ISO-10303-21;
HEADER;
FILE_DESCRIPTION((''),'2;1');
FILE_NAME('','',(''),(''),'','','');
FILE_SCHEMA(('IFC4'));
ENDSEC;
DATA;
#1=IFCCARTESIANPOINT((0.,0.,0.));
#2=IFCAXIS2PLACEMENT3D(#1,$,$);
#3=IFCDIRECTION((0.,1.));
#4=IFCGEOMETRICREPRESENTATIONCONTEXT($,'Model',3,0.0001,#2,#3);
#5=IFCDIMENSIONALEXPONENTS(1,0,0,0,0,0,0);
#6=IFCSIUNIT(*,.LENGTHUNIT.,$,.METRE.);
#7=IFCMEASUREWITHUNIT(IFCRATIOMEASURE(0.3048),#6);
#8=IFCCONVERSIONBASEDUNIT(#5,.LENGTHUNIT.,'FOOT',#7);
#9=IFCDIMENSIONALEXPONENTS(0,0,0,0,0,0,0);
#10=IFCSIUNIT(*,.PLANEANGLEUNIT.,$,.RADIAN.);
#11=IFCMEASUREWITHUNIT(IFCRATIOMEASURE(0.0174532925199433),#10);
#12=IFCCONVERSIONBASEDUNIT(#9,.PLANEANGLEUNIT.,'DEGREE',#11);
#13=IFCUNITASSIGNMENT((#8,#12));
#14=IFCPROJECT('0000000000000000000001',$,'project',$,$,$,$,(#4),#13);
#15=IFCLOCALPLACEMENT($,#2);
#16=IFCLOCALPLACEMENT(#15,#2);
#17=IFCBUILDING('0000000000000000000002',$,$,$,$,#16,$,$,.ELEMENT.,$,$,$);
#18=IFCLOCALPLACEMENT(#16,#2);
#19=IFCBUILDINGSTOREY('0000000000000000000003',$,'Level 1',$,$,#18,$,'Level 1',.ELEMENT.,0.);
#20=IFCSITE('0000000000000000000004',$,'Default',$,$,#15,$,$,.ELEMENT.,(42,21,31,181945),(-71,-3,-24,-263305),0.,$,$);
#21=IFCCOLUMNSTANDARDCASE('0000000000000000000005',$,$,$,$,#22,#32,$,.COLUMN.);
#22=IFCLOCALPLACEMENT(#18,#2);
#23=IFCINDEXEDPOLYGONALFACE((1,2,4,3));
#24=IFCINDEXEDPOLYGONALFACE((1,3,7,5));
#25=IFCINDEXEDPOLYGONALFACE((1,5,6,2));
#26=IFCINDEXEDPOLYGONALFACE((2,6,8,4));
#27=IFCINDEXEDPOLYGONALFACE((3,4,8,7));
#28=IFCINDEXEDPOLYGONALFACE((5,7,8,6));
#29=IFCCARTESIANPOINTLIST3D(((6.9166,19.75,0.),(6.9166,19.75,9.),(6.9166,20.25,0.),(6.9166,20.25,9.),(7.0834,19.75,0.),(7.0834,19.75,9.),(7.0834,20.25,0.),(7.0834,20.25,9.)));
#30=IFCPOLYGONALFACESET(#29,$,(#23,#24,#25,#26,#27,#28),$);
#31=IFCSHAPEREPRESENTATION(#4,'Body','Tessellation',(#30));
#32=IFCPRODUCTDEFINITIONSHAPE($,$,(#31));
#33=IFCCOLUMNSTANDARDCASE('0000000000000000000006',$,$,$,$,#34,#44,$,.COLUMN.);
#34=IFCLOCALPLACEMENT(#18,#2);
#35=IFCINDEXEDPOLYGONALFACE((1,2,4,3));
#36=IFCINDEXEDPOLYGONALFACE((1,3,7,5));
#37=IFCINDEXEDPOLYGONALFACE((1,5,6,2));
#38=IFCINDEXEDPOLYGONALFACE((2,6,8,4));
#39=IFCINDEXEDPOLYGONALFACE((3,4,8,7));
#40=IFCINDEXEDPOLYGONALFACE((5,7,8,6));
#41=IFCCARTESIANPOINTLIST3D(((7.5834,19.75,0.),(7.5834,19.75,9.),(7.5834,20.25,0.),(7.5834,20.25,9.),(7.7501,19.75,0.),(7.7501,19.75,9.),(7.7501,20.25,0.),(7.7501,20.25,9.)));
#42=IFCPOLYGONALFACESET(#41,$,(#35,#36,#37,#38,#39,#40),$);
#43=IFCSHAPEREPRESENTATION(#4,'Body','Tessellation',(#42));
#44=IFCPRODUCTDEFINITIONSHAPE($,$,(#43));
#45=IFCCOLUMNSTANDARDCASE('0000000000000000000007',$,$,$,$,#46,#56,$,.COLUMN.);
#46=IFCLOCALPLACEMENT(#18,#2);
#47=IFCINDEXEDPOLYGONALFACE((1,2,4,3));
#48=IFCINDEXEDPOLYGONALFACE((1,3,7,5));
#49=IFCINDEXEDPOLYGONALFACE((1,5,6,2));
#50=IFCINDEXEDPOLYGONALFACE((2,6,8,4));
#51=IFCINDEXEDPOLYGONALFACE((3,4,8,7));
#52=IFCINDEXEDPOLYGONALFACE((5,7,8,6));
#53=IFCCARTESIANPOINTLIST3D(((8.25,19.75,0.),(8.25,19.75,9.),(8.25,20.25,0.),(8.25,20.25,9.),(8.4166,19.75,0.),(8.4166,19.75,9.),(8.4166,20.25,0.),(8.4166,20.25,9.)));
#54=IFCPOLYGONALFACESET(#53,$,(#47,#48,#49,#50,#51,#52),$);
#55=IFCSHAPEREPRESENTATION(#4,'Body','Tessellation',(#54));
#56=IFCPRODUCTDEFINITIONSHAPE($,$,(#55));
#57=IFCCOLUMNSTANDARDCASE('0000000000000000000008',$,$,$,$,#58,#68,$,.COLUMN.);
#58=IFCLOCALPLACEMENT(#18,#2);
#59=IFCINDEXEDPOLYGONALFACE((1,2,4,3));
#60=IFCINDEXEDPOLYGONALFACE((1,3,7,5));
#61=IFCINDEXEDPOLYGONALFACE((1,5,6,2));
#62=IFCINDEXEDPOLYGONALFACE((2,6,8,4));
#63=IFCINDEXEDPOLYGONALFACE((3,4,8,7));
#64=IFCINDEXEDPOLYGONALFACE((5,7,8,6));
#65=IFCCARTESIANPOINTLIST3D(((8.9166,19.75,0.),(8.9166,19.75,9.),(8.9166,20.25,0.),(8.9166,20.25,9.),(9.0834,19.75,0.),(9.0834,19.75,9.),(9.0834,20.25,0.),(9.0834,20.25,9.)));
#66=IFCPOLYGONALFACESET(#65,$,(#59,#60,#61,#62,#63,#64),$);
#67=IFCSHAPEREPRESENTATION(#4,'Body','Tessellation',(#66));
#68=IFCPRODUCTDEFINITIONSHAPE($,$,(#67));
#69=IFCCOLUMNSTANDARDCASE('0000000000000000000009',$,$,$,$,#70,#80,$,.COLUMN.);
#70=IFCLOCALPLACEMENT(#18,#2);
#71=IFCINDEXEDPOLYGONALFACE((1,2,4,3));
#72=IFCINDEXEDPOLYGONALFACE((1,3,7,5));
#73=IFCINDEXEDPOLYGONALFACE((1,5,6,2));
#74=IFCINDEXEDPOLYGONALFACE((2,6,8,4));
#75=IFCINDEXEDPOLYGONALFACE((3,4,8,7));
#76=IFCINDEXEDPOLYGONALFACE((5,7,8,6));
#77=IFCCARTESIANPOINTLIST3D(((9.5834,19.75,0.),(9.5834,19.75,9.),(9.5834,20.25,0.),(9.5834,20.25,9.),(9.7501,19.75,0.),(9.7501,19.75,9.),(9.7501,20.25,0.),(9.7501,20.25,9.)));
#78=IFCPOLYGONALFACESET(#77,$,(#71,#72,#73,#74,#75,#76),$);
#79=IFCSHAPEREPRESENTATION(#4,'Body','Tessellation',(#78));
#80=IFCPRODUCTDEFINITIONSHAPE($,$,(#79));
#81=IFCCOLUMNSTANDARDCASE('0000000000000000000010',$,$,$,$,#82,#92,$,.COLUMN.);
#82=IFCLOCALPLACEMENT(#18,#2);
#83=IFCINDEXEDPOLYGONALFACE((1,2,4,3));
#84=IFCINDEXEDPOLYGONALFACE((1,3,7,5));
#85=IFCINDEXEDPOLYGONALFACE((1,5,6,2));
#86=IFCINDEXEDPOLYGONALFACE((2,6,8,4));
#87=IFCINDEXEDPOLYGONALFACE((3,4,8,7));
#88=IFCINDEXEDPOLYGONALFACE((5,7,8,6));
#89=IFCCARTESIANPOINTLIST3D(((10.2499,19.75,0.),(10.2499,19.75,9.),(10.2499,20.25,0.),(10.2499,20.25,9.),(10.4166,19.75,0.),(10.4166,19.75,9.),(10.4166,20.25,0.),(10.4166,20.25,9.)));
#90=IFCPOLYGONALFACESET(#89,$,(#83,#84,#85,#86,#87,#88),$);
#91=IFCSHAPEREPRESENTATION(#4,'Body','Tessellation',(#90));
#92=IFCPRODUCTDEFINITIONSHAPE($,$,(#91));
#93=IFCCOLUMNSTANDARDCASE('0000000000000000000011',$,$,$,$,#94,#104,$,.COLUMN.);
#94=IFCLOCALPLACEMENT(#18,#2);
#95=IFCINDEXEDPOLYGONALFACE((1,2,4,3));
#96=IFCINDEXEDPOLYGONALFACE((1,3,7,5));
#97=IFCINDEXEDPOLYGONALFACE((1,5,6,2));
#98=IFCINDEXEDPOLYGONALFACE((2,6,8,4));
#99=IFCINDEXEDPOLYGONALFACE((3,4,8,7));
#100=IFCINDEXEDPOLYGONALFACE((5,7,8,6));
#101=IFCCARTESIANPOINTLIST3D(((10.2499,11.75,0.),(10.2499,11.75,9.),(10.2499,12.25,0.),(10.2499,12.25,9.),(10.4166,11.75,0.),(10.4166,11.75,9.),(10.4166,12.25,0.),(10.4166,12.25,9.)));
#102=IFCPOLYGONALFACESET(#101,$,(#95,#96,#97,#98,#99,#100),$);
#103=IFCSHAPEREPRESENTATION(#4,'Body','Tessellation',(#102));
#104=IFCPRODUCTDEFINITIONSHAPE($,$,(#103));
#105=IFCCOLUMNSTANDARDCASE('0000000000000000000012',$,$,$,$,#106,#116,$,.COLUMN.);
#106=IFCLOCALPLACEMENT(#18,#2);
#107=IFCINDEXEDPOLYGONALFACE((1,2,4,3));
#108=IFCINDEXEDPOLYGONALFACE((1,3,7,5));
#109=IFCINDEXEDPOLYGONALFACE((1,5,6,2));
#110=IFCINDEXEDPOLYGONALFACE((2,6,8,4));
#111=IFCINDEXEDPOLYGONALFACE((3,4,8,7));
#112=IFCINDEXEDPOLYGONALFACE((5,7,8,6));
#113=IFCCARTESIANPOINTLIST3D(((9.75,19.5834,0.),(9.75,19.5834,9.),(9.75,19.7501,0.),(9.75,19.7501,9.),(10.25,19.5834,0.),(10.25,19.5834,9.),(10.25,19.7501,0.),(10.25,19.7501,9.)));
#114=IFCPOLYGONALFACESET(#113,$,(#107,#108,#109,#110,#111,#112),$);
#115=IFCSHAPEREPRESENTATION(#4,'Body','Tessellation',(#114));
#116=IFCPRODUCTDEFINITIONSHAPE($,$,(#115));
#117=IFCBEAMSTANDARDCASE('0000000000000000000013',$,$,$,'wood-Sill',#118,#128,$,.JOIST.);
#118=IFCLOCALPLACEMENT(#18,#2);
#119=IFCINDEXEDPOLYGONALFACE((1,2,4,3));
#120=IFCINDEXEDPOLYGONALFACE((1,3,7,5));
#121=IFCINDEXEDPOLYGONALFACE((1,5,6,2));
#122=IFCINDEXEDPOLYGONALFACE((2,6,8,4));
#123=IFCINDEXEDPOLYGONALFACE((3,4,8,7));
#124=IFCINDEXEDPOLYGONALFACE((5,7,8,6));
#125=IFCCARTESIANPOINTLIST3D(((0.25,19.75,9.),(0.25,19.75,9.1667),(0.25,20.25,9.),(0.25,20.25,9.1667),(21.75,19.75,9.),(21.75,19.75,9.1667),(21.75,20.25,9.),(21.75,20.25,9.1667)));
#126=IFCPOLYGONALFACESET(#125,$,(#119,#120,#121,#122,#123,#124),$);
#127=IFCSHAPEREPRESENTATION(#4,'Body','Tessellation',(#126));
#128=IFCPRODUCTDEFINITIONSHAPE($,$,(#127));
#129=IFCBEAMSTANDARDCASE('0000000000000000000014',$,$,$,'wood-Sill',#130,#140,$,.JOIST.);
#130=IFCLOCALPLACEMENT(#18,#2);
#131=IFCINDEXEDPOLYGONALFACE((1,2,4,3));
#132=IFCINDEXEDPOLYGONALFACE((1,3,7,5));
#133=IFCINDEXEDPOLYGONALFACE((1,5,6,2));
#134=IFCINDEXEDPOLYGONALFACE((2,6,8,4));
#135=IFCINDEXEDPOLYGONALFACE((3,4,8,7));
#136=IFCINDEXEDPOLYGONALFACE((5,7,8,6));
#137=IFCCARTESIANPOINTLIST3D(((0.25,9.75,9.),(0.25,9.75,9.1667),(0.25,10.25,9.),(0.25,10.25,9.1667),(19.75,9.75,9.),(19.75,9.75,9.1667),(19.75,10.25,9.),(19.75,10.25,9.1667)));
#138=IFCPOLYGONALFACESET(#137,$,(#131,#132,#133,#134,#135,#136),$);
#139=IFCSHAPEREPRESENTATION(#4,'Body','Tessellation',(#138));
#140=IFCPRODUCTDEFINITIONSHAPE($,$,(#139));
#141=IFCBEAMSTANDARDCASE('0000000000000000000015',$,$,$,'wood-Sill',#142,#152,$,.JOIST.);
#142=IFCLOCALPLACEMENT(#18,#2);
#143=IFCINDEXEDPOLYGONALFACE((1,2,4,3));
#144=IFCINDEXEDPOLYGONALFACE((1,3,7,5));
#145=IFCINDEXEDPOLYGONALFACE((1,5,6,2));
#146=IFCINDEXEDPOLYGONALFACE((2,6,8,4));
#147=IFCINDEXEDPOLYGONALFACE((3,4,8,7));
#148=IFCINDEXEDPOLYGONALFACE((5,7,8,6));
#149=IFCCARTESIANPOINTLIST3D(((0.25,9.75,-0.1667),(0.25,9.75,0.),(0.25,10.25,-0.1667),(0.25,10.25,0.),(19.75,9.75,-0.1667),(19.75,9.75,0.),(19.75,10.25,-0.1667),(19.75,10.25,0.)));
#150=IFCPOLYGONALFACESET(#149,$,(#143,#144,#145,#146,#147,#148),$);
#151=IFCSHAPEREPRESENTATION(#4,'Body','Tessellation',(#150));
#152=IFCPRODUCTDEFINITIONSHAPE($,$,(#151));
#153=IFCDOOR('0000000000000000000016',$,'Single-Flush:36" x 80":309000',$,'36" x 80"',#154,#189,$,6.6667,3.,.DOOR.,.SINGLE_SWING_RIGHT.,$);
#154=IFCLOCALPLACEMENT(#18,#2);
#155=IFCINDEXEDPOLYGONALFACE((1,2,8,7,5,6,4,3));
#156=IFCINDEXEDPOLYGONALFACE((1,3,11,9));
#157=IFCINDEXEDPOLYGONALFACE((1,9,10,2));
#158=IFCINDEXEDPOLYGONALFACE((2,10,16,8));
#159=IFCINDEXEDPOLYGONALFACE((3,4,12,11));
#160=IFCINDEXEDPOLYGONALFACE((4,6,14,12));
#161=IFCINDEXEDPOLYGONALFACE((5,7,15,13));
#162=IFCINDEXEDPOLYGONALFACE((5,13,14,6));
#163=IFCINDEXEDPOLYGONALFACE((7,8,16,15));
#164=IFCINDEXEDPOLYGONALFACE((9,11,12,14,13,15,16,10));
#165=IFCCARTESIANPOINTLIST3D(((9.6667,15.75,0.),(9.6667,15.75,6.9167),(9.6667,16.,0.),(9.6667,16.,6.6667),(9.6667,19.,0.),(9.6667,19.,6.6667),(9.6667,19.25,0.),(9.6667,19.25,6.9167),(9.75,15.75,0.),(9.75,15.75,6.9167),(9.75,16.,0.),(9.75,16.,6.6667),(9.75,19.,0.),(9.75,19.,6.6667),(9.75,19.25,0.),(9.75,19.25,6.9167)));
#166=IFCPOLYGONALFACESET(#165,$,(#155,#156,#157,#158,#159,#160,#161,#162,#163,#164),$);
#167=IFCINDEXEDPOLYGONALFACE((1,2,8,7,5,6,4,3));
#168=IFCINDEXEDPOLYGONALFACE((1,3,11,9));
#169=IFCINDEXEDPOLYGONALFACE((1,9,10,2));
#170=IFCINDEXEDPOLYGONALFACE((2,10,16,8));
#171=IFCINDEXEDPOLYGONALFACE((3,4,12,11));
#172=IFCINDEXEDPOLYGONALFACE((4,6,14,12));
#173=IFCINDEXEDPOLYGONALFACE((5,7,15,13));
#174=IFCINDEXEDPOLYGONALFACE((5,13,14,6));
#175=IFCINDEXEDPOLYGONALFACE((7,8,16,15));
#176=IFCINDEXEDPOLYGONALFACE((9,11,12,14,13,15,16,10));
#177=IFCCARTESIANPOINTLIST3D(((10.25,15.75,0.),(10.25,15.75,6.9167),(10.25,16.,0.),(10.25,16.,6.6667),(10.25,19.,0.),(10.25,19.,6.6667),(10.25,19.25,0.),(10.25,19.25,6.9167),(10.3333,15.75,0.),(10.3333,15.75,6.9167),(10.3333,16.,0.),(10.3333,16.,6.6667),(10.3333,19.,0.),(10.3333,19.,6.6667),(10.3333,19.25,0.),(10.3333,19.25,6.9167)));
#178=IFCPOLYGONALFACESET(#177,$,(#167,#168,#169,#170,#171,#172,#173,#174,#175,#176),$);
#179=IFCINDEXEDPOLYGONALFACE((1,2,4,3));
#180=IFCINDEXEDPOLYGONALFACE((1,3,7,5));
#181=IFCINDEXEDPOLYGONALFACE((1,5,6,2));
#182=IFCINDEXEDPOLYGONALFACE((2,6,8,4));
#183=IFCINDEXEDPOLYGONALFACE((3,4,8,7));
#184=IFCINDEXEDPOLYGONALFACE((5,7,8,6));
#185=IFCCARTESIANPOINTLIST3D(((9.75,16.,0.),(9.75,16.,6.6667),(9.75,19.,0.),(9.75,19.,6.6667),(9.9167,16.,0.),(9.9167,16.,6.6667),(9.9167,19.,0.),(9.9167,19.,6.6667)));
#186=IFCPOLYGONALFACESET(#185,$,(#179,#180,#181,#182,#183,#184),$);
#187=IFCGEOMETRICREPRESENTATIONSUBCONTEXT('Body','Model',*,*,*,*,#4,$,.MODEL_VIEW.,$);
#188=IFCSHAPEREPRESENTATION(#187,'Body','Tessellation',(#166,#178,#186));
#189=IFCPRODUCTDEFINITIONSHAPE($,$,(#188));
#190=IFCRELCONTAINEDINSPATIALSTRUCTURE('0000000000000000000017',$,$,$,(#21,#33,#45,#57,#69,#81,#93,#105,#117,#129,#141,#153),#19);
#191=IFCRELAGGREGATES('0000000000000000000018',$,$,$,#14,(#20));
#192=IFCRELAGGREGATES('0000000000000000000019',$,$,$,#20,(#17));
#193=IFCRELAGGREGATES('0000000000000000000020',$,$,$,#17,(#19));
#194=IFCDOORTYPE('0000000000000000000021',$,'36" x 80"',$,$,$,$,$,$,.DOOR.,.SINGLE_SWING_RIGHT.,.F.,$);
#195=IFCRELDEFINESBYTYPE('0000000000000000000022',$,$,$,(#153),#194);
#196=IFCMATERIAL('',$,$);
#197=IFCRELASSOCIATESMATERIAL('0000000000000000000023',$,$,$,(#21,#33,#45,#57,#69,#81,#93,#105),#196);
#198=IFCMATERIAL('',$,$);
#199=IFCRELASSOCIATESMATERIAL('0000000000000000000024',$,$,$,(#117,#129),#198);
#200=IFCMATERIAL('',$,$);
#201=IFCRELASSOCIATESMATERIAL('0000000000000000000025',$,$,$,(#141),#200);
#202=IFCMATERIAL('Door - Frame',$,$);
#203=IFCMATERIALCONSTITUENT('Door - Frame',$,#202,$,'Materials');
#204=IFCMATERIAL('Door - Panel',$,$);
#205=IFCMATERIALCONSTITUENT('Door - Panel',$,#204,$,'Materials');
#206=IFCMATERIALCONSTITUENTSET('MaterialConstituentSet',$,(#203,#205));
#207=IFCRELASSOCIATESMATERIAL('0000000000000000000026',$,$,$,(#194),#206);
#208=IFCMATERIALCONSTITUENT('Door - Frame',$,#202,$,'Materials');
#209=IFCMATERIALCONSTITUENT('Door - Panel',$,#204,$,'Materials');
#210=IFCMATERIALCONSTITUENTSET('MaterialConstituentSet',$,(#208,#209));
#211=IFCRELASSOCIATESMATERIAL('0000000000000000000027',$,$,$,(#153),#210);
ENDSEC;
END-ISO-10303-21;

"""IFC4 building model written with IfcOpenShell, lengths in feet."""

from ifc_helpers import new_model, entity, si_unit, converted_unit, direction, frame, origin, origin_2d_with_axis, place, context, subcontext, project, spatial, polyline, rectangle, outline, extrude, source, transform, mapped, material, constituent, constituent_set, type_object, type_shapes, element, save


model = new_model("IFC4")

# Units and contexts
model_context = context("Model", 3, precision=0.0001, world=origin(), true_north=direction((0.0, 1.0)))
body_context = subcontext(model_context, "Body", "Model", "MODEL_VIEW")
ifc_project = project(units=[converted_unit("LENGTHUNIT", "FOOT", entity("IfcRatioMeasure", 0.3048), si_unit("LENGTHUNIT", "METRE"), dimensions=[1, 0, 0, 0, 0, 0, 0]), converted_unit("PLANEANGLEUNIT", "DEGREE", entity("IfcRatioMeasure", 0.0174532925199433), si_unit("PLANEANGLEUNIT", "RADIAN"), dimensions=[0, 0, 0, 0, 0, 0, 0])], contexts=[model_context])

# Site, building, storey
site_placement = place(None, origin())
site = spatial("IfcSite", under=ifc_project, at=site_placement, Name="Default", CompositionType="ELEMENT", RefLatitude=(42, 21, 31, 181945), RefLongitude=(-71, -3, -24, -263305), RefElevation=0.0)
building_placement = place(site_placement, origin())
building = spatial("IfcBuilding", under=site, at=building_placement, CompositionType="ELEMENT")
storey_placement = place(building_placement, origin())
storey = spatial("IfcBuildingStorey", under=building, at=storey_placement, Name="Level 1", LongName="Level 1", CompositionType="ELEMENT", Elevation=0.0)

# Columns
ifc_material_1 = material(Name="")
placement_1 = place(storey_placement, frame((0.25, 20.0, 0.0)))
for number, where, z_axis, x_axis in (
    (1, (6.75, 0.0, 0.0), (0.0, 0.0, 1.0), (1.0, 0.0, 0.0)),
    (2, (7.4167, 0.0, 0.0), (0.0, 0.0, 1.0), (1.0, 0.0, 0.0)),
    (3, (8.0833, 0.0, 0.0), (0.0, 0.0, 1.0), (1.0, 0.0, 0.0)),
    (4, (8.75, 0.0, 0.0), (0.0, 0.0, 1.0), (1.0, 0.0, 0.0)),
    (5, (9.4167, 0.0, 0.0), (0.0, 0.0, 1.0), (1.0, 0.0, 0.0)),
    (6, (10.0833, 0.0, 0.0), (0.0, 0.0, 1.0), (1.0, 0.0, 0.0)),
):
    element("IfcColumnStandardCase", number, at=place(placement_1, frame(where, z_axis=z_axis, x_axis=x_axis)), inside=storey, material=ifc_material_1, PredefinedType="COLUMN", context=model_context, shape_type="SweptSolid", body=[
        extrude(rectangle(XDim=0.1667, YDim=0.5), origin(), (0.0, 0.0, 1.0), 9.0),
    ])
placement_2 = place(storey_placement, frame((10.25, 12.0, 0.0)))
for number, where, z_axis, x_axis in (
    (7, (0.0833, 0.0, 0.0), (0.0, 0.0, 1.0), (1.0, 0.0, 0.0)),
):
    element("IfcColumnStandardCase", number, at=place(placement_2, frame(where, z_axis=z_axis, x_axis=x_axis)), inside=storey, material=ifc_material_1, PredefinedType="COLUMN", context=model_context, shape_type="SweptSolid", body=[
        extrude(rectangle(XDim=0.1667, YDim=0.5), origin(), (0.0, 0.0, 1.0), 9.0),
    ])
placement_3 = place(storey_placement, frame((10.0, 19.75, 0.0), z_axis=(0.0, 0.0, 1.0), x_axis=(0.0, -1.0, 0.0)))
for number, where, z_axis, x_axis in (
    (8, (0.0833, 0.0, 0.0), (0.0, 0.0, 1.0), (1.0, 0.0, 0.0)),
):
    element("IfcColumnStandardCase", number, at=place(placement_3, frame(where, z_axis=z_axis, x_axis=x_axis)), inside=storey, material=ifc_material_1, PredefinedType="COLUMN", context=model_context, shape_type="SweptSolid", body=[
        extrude(rectangle(XDim=0.1667, YDim=0.5), origin(), (0.0, 0.0, 1.0), 9.0),
    ])

# Beams
ifc_material_2 = material(Name="")
beam_1_placement = place(placement_1, frame((10.75, 0.0, 9.0), z_axis=(0.0, 0.0, 1.0), x_axis=(1.0, 0.0, 0.0)))
element("IfcBeamStandardCase", 9, at=beam_1_placement, inside=storey, material=ifc_material_2, ObjectType="wood-Sill", PredefinedType="JOIST", context=model_context, shape_type="SweptSolid", body=[
    extrude(rectangle(XDim=21.5, YDim=0.5), origin(), (0.0, 0.0, 1.0), 0.1667),
])
beam_2_placement = place(placement_3, frame((9.75, 0.0, 9.0), z_axis=(0.0, 0.0, 1.0), x_axis=(0.0, -1.0, 0.0)))
element("IfcBeamStandardCase", 10, at=beam_2_placement, inside=storey, material=ifc_material_2, ObjectType="wood-Sill", PredefinedType="JOIST", context=model_context, shape_type="SweptSolid", body=[
    extrude(rectangle(XDim=19.5, YDim=0.5), origin(), (0.0, 0.0, 1.0), 0.1667),
])
ifc_material_3 = material(Name="")
beam_3_placement = place(placement_3, frame((9.75, 0.0, -0.1667), z_axis=(0.0, 0.0, 1.0), x_axis=(0.0, -1.0, 0.0)))
element("IfcBeamStandardCase", 11, at=beam_3_placement, inside=storey, material=ifc_material_3, ObjectType="wood-Sill", PredefinedType="JOIST", context=model_context, shape_type="SweptSolid", body=[
    extrude(rectangle(XDim=19.5, YDim=0.5), origin(), (0.0, 0.0, 1.0), 0.1667),
])

# Door
ifc_material_4 = material(Name="Door - Frame")
ifc_constituent_1 = constituent(ifc_material_4, Name="Door - Frame", Category="Materials")
ifc_material_5 = material(Name="Door - Panel")
ifc_constituent_2 = constituent(ifc_material_5, Name="Door - Panel", Category="Materials")
ifc_constituent_set_1 = constituent_set(constituents=[ifc_constituent_1, ifc_constituent_2], Name="MaterialConstituentSet")
ifc_constituent_3 = constituent(ifc_material_4, Name="Door - Frame", Category="Materials")
ifc_constituent_4 = constituent(ifc_material_5, Name="Door - Panel", Category="Materials")
ifc_constituent_set_2 = constituent_set(constituents=[ifc_constituent_3, ifc_constituent_4], Name="MaterialConstituentSet")
door_type = type_object("IfcDoorType", Name="36\" x 80\"", OperationType="SINGLE_SWING_RIGHT", ParameterTakesPrecedence=False, PredefinedType="DOOR", material=ifc_constituent_set_2)
shared_shape = source(origin(), body_context, "Body", "SweptSolid", [
    extrude(outline(polyline([(-1.75, -3.5208), (1.75, -3.5208), (1.75, 3.3958), (1.5, 3.3958), (1.5, -3.2708), (-1.5, -3.2708), (-1.5, 3.3958), (-1.75, 3.3958), (-1.75, -3.5208)])), frame((1.5, 0.5, 3.3958), z_axis=(0.0, 1.0, 0.0), x_axis=(1.0, 0.0, 0.0)), (0.0, 0.0, 1.0), 0.0833),
    extrude(outline(polyline([(-3.5208, -1.75), (3.3958, -1.75), (3.3958, -1.5), (-3.2708, -1.5), (-3.2708, 1.5), (3.3958, 1.5), (3.3958, 1.75), (-3.5208, 1.75), (-3.5208, -1.75)])), frame((1.5, -0.0833, 3.3958), z_axis=(0.0, 1.0, 0.0), x_axis=(0.0, 0.0, -1.0)), (0.0, 0.0, 1.0), 0.0833),
    extrude(rectangle(XDim=0.1667, YDim=3.0, at=origin_2d_with_axis()), frame((1.5, 0.4167, 0.0), z_axis=(0.0, 0.0, 1.0), x_axis=(0.0, 1.0, 0.0)), (0.0, 0.0, 1.0), 6.6667),
])
type_shapes(door_type, [shared_shape])
placement_4 = place(placement_3, frame((3.75, 0.25, 0.0)))
door_placement = place(placement_4, frame((0.0, 0.0, 0.0), z_axis=(0.0, 0.0, 1.0), x_axis=(-1.0, 0.0, 0.0)))
element("IfcDoor", 12, at=door_placement, inside=storey, type_object=door_type, material=ifc_constituent_set_1, Name="Single-Flush:36\" x 80\":309000", ObjectType="36\" x 80\"", OperationType="SINGLE_SWING_RIGHT", OverallHeight=6.6667, OverallWidth=3.0, PredefinedType="DOOR", context=body_context, shape_type="MappedRepresentation", body=[
    mapped(shared_shape, transform((0.0, 0.0, 0.0), scale=1.0)),
])

save(model, "model.ifc")
